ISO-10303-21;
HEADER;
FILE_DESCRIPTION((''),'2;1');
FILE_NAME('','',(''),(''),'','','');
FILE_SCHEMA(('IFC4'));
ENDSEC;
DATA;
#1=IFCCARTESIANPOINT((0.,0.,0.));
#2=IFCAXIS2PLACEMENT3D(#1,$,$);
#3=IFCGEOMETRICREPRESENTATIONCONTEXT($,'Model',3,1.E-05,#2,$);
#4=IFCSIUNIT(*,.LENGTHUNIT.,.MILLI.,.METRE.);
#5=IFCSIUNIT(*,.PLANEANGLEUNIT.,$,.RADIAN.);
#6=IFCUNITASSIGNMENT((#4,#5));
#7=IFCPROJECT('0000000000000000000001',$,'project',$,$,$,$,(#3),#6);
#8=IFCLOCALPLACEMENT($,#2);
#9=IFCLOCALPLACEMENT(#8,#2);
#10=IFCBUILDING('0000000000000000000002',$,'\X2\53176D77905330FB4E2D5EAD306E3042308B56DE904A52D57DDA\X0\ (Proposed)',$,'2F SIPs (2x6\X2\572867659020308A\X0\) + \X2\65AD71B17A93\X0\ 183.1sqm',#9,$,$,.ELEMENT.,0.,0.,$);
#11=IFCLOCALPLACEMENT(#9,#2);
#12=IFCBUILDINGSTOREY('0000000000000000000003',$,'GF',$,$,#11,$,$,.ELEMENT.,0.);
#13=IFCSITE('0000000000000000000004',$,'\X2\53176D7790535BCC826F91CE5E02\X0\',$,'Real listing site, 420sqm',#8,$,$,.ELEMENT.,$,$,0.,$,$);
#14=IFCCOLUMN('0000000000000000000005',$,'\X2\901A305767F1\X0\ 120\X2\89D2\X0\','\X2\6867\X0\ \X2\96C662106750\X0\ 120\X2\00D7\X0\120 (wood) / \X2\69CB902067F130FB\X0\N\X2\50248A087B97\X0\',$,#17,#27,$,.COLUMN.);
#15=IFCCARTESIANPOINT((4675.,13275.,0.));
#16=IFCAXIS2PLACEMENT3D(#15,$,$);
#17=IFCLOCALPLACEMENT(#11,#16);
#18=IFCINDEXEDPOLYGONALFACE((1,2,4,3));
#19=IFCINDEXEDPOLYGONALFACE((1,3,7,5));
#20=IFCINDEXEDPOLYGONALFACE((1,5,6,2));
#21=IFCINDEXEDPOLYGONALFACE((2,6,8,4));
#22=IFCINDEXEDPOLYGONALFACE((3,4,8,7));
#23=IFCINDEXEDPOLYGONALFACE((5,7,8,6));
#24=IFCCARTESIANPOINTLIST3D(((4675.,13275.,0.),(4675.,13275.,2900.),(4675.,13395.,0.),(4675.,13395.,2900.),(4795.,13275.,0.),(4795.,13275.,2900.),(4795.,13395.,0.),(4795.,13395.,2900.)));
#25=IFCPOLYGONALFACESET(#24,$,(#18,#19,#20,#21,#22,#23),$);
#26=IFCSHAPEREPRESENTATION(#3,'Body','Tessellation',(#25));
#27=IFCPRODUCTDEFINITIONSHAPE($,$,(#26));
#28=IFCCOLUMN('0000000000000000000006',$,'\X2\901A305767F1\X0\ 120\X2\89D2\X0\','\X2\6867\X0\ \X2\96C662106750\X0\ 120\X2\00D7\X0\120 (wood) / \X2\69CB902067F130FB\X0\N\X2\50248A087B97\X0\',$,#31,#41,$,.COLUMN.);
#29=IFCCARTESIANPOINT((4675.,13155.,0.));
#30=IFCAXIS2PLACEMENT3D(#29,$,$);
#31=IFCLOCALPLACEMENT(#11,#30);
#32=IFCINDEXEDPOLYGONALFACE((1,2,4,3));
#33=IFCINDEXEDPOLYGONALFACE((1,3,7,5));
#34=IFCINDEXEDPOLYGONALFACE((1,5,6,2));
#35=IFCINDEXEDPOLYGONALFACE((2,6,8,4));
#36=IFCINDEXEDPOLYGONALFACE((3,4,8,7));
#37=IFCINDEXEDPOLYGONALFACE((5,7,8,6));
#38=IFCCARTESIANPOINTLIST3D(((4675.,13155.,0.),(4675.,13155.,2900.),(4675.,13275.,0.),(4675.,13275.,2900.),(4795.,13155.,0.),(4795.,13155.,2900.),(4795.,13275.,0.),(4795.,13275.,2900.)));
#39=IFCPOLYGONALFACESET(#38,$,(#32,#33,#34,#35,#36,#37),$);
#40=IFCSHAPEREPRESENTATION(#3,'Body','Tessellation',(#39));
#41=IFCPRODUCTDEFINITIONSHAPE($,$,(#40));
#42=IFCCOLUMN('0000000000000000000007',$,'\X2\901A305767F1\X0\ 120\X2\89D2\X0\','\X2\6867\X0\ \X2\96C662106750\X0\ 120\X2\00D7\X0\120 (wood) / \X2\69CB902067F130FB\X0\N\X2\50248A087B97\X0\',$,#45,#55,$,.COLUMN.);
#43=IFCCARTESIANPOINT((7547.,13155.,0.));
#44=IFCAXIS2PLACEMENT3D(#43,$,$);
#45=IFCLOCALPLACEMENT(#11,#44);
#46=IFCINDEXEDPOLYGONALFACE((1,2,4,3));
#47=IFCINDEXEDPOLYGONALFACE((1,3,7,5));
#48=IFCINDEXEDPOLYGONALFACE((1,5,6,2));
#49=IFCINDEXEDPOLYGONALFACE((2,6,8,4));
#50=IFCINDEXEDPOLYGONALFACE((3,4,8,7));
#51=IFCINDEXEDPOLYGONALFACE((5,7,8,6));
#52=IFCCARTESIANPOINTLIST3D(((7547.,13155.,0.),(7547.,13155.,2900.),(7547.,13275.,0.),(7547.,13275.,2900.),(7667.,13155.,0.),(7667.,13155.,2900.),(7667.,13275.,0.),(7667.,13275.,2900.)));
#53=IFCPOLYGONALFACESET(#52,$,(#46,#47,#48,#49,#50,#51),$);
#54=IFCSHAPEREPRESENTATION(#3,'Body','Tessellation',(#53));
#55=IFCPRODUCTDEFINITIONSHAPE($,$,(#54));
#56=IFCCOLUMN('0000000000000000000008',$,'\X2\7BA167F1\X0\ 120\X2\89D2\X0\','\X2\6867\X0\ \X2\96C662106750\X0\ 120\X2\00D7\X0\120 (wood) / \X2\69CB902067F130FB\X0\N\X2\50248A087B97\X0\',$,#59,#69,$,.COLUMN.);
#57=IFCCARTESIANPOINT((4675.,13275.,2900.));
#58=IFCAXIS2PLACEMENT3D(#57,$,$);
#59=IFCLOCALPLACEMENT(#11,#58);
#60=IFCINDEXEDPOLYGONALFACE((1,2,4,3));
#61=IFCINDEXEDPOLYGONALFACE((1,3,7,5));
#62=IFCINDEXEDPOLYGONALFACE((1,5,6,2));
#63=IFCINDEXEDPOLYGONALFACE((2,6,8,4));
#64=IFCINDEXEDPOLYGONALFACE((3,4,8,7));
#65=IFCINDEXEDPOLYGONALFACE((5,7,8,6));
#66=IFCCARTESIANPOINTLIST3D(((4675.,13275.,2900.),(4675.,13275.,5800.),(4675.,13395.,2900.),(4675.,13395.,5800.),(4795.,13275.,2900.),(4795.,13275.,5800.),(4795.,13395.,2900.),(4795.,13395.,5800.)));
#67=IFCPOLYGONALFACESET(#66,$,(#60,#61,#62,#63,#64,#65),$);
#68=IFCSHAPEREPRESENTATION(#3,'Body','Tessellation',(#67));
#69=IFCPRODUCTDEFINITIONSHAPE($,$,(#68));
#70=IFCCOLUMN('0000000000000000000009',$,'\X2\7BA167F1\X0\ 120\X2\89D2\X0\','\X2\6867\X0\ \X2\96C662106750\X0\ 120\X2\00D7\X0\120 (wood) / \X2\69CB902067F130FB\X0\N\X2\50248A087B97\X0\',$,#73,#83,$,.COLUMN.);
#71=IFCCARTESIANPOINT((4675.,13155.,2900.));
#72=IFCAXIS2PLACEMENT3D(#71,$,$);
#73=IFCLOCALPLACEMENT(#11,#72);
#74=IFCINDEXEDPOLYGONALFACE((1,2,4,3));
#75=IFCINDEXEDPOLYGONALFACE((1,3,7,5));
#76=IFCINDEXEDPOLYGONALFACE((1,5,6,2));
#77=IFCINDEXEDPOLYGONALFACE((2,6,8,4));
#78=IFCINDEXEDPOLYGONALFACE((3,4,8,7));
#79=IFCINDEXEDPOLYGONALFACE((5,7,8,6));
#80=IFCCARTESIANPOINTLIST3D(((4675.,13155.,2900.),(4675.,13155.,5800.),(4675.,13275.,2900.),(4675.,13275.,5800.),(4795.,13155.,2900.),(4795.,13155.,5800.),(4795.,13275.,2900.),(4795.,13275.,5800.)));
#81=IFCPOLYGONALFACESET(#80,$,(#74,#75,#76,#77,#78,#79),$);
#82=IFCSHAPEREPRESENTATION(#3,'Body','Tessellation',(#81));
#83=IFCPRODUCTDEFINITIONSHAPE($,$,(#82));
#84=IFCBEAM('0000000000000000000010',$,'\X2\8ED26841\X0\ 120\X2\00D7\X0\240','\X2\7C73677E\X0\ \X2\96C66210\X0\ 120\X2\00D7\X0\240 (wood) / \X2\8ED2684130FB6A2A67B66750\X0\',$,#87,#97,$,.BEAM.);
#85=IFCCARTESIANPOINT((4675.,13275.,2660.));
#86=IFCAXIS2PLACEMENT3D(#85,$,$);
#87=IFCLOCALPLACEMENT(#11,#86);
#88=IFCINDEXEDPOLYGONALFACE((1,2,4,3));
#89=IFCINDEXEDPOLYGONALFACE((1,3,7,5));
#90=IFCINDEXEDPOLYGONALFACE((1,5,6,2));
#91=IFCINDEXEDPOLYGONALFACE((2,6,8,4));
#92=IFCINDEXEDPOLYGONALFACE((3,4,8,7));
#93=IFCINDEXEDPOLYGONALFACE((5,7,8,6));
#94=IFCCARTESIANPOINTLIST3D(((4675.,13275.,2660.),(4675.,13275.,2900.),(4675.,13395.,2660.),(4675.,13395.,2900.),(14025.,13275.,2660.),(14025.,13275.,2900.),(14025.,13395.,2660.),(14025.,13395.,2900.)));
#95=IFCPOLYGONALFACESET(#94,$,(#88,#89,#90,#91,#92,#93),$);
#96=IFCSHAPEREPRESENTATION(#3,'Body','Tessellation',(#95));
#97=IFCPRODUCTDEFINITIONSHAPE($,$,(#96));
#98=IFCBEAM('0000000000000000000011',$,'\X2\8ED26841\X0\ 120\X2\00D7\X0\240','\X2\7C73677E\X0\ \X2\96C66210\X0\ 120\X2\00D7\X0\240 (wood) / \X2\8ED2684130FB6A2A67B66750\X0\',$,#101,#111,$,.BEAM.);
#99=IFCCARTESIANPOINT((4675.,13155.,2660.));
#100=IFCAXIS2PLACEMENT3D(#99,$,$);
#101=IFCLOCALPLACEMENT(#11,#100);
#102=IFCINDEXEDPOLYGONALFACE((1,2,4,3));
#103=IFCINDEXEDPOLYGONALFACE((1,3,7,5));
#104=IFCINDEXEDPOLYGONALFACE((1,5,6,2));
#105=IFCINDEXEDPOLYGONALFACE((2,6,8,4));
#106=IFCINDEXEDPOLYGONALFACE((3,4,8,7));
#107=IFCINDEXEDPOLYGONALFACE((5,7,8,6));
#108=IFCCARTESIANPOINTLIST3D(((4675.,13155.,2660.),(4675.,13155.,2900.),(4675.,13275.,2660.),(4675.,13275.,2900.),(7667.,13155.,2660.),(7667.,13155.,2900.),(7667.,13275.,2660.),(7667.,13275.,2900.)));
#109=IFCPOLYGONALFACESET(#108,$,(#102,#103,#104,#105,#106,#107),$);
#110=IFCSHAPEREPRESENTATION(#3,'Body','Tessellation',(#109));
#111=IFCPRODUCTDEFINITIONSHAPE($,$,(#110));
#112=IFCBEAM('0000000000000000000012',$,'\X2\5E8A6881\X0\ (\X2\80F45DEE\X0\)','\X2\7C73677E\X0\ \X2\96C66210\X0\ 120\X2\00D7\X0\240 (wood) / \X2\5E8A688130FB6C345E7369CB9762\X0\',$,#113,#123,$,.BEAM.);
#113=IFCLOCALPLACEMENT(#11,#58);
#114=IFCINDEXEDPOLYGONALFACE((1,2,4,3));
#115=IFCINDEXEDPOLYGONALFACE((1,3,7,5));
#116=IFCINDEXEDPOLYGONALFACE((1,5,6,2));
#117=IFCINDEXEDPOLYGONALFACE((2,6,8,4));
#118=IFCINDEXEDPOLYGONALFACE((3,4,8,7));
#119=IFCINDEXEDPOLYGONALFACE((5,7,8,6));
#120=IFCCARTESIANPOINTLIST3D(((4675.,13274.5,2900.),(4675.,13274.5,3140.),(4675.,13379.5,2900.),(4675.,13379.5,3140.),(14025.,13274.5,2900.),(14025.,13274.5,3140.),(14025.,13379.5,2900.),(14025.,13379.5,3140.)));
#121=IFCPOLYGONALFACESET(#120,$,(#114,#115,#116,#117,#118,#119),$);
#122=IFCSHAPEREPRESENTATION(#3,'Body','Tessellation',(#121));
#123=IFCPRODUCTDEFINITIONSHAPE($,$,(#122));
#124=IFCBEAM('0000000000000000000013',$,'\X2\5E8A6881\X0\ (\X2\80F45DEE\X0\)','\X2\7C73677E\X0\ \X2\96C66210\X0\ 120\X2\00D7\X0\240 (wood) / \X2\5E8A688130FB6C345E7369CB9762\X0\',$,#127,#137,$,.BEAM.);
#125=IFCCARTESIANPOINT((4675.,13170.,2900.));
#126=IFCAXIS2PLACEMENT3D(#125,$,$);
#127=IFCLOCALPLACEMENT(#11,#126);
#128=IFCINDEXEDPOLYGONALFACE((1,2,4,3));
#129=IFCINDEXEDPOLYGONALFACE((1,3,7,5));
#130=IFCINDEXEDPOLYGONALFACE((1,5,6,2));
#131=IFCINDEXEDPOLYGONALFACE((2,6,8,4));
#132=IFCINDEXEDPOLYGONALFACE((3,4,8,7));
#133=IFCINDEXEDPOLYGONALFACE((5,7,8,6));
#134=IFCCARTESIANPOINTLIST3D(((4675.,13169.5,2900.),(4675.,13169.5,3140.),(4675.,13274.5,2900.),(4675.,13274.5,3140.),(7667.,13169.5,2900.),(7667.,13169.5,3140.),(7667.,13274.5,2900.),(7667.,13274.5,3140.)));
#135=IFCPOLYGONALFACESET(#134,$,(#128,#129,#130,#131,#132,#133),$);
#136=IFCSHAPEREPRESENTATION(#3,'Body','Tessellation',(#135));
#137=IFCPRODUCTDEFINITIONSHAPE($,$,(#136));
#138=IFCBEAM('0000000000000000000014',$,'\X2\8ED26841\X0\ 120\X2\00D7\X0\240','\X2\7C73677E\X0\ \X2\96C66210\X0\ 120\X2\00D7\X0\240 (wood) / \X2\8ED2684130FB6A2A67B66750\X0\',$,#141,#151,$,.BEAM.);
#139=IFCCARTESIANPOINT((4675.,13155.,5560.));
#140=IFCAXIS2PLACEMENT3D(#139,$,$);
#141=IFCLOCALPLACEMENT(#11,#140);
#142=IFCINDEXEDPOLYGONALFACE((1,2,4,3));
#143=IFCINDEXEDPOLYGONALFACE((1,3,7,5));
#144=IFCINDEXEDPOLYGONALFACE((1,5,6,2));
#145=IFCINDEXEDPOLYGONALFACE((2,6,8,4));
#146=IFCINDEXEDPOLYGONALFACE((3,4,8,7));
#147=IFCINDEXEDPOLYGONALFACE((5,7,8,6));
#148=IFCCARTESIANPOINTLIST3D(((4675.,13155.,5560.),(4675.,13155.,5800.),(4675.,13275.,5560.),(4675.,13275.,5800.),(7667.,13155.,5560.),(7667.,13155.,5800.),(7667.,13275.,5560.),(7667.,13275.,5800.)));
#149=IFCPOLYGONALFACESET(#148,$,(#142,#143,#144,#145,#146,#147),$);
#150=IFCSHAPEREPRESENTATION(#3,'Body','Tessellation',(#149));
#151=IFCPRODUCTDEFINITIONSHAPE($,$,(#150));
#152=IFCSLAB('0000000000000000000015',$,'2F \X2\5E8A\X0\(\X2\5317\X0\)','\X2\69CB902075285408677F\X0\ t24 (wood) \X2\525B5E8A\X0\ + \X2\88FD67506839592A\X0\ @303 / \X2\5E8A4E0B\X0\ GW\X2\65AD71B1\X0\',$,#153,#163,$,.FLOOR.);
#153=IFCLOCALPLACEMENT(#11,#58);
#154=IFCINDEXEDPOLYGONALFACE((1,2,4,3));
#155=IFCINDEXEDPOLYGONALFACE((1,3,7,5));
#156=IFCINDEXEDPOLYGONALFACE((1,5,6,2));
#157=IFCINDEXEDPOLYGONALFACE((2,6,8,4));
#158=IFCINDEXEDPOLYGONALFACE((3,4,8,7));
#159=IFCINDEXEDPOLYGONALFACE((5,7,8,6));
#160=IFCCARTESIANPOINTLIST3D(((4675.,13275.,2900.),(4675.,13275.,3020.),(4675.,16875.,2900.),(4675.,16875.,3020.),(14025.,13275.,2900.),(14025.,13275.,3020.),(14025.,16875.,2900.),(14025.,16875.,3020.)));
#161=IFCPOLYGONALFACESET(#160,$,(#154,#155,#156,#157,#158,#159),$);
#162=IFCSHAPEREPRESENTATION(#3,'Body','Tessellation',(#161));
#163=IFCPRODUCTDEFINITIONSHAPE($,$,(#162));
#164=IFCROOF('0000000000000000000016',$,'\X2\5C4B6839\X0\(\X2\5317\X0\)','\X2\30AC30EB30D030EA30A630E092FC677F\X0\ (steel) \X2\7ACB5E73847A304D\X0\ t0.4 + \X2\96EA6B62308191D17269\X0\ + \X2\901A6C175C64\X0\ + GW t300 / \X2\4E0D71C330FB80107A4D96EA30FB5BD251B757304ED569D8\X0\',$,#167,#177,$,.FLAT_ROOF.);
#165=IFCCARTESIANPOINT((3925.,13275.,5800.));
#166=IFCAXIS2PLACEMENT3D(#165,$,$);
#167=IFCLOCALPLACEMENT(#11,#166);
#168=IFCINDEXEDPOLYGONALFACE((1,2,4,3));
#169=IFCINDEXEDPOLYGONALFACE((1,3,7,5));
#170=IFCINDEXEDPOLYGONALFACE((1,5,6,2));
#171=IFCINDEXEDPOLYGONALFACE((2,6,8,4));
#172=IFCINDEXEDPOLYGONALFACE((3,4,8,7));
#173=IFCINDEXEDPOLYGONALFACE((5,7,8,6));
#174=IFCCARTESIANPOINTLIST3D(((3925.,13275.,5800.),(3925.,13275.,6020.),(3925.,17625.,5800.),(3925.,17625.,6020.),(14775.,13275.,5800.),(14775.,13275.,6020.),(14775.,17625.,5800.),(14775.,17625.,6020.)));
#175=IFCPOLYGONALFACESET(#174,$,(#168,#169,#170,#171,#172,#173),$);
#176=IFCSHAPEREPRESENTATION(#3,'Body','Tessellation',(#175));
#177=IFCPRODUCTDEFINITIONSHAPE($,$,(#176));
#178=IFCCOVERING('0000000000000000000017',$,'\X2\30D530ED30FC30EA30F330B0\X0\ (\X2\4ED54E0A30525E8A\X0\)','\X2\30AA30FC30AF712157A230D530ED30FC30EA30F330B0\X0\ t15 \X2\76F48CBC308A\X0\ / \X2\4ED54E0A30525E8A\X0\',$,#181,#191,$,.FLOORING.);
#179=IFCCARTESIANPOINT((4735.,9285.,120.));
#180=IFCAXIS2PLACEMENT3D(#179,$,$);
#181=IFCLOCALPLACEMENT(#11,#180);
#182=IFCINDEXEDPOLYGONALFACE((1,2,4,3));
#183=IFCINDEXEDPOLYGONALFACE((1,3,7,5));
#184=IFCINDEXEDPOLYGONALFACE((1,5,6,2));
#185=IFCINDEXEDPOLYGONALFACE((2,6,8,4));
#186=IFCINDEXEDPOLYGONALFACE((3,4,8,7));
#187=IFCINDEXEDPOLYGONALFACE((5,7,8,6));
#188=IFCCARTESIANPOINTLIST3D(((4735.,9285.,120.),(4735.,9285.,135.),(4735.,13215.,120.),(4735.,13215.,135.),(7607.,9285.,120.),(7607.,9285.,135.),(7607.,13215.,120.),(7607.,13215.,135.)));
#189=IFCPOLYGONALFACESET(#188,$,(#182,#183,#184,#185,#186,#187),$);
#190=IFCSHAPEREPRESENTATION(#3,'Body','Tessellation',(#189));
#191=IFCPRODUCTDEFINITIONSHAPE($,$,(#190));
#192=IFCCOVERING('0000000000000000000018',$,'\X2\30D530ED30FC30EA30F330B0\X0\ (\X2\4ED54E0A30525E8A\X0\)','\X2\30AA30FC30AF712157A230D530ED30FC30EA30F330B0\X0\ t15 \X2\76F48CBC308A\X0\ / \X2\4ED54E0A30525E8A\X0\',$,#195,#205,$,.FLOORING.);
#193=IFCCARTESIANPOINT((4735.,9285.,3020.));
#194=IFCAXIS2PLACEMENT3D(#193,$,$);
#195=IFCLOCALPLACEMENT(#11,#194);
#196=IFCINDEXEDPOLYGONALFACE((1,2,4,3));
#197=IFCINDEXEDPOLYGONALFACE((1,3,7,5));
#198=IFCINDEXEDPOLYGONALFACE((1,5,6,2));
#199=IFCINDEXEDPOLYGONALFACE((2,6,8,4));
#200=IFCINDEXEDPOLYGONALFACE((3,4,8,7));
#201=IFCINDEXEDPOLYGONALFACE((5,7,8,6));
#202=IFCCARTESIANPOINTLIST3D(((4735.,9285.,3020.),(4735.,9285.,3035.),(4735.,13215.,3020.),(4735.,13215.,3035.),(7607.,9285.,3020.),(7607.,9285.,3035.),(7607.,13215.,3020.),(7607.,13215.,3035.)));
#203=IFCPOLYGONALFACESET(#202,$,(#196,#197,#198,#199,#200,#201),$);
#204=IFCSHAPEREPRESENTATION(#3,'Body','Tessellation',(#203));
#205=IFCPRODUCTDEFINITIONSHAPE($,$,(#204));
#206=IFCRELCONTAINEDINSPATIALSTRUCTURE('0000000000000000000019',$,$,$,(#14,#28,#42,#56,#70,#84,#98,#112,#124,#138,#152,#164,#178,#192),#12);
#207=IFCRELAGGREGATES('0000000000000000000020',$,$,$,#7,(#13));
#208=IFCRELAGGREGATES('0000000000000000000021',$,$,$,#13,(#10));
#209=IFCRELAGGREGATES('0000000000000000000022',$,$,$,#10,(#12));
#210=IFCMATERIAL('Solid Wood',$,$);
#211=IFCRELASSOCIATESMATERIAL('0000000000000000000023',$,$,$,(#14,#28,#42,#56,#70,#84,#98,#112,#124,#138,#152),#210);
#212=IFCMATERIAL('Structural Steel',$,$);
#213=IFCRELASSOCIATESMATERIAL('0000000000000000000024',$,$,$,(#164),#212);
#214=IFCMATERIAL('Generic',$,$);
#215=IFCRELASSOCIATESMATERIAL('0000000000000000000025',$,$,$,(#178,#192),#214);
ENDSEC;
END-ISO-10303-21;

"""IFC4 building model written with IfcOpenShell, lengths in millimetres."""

from ifc_helpers import new_model, si_unit, frame, frame_2d, origin, place, context, project, spatial, rectangle, extrude, material, element, save


model = new_model("IFC4")

# Units and contexts
model_context = context("Model", 3, precision=1e-05, world=origin())
ifc_project = project(units=[si_unit("LENGTHUNIT", "METRE", prefix="MILLI"), si_unit("PLANEANGLEUNIT", "RADIAN")], contexts=[model_context])

# Site, building, storey
site_placement = place(None, origin())
site = spatial("IfcSite", under=ifc_project, at=site_placement, Name="北海道富良野市", ObjectType="Real listing site, 420sqm", CompositionType="ELEMENT", RefElevation=0.0)
building_placement = place(site_placement, origin())
building = spatial("IfcBuilding", under=site, at=building_placement, Name="北海道・中庭のある回遊動線 (Proposed)", ObjectType="2F SIPs (2x6在来造り) + 断熱窓 183.1sqm", CompositionType="ELEMENT", ElevationOfRefHeight=0.0, ElevationOfTerrain=0.0)
storey_placement = place(building_placement, origin())
storey = spatial("IfcBuildingStorey", under=building, at=storey_placement, Name="GF", CompositionType="ELEMENT", Elevation=0.0)

# Columns
ifc_material_1 = material(Name="Solid Wood")
column_1_placement = place(storey_placement, frame((4675.0, 13275.0, 0.0)))
element("IfcColumn", 1, at=column_1_placement, inside=storey, material=ifc_material_1, Name="通し柱 120角", Description="桧 集成材 120×120 (wood) / 構造柱・N値計算", PredefinedType="COLUMN", context=model_context, shape_type="SweptSolid", body=[
    extrude(rectangle(XDim=120.0, YDim=120.0, at=frame_2d((60.0, 60.0))), frame((4675.0, 13275.0, 0.0)), (0.0, 0.0, 1.0), 2900.0),
])
column_2_placement = place(storey_placement, frame((4675.0, 13155.0, 0.0)))
element("IfcColumn", 2, at=column_2_placement, inside=storey, material=ifc_material_1, Name="通し柱 120角", Description="桧 集成材 120×120 (wood) / 構造柱・N値計算", PredefinedType="COLUMN", context=model_context, shape_type="SweptSolid", body=[
    extrude(rectangle(XDim=120.0, YDim=120.0, at=frame_2d((60.0, 60.0))), frame((4675.0, 13155.0, 0.0)), (0.0, 0.0, 1.0), 2900.0),
])
column_3_placement = place(storey_placement, frame((7547.0, 13155.0, 0.0)))
element("IfcColumn", 3, at=column_3_placement, inside=storey, material=ifc_material_1, Name="通し柱 120角", Description="桧 集成材 120×120 (wood) / 構造柱・N値計算", PredefinedType="COLUMN", context=model_context, shape_type="SweptSolid", body=[
    extrude(rectangle(XDim=120.0, YDim=120.0, at=frame_2d((60.0, 60.0))), frame((7547.0, 13155.0, 0.0)), (0.0, 0.0, 1.0), 2900.0),
])
column_4_placement = place(storey_placement, frame((4675.0, 13275.0, 2900.0)))
element("IfcColumn", 4, at=column_4_placement, inside=storey, material=ifc_material_1, Name="管柱 120角", Description="桧 集成材 120×120 (wood) / 構造柱・N値計算", PredefinedType="COLUMN", context=model_context, shape_type="SweptSolid", body=[
    extrude(rectangle(XDim=120.0, YDim=120.0, at=frame_2d((60.0, 60.0))), frame((4675.0, 13275.0, 2900.0)), (0.0, 0.0, 1.0), 2900.0),
])
column_5_placement = place(storey_placement, frame((4675.0, 13155.0, 2900.0)))
element("IfcColumn", 5, at=column_5_placement, inside=storey, material=ifc_material_1, Name="管柱 120角", Description="桧 集成材 120×120 (wood) / 構造柱・N値計算", PredefinedType="COLUMN", context=model_context, shape_type="SweptSolid", body=[
    extrude(rectangle(XDim=120.0, YDim=120.0, at=frame_2d((60.0, 60.0))), frame((4675.0, 13155.0, 2900.0)), (0.0, 0.0, 1.0), 2900.0),
])

# Beams
beam_1_placement = place(storey_placement, frame((4675.0, 13275.0, 2660.0)))
element("IfcBeam", 6, at=beam_1_placement, inside=storey, material=ifc_material_1, Name="軒桁 120×240", Description="米松 集成 120×240 (wood) / 軒桁・横架材", PredefinedType="BEAM", context=model_context, shape_type="SweptSolid", body=[
    extrude(rectangle(XDim=9350.0, YDim=120.0, at=frame_2d((4675.0, 60.0))), frame((4675.0, 13275.0, 2660.0)), (0.0, 0.0, 1.0), 240.0),
])
beam_2_placement = place(storey_placement, frame((4675.0, 13155.0, 2660.0)))
element("IfcBeam", 7, at=beam_2_placement, inside=storey, material=ifc_material_1, Name="軒桁 120×240", Description="米松 集成 120×240 (wood) / 軒桁・横架材", PredefinedType="BEAM", context=model_context, shape_type="SweptSolid", body=[
    extrude(rectangle(XDim=2992.0, YDim=120.0, at=frame_2d((1496.0, 60.0))), frame((4675.0, 13155.0, 2660.0)), (0.0, 0.0, 1.0), 240.0),
])
beam_3_placement = place(storey_placement, frame((4675.0, 13275.0, 2900.0)))
element("IfcBeam", 8, at=beam_3_placement, inside=storey, material=ifc_material_1, Name="床梁 (胴差)", Description="米松 集成 120×240 (wood) / 床梁・水平構面", PredefinedType="BEAM", context=model_context, shape_type="SweptSolid", body=[
    extrude(rectangle(XDim=9350.0, YDim=105.0, at=frame_2d((4675.0, 52.0))), frame((4675.0, 13275.0, 2900.0)), (0.0, 0.0, 1.0), 240.0),
])
beam_4_placement = place(storey_placement, frame((4675.0, 13170.0, 2900.0)))
element("IfcBeam", 9, at=beam_4_placement, inside=storey, material=ifc_material_1, Name="床梁 (胴差)", Description="米松 集成 120×240 (wood) / 床梁・水平構面", PredefinedType="BEAM", context=model_context, shape_type="SweptSolid", body=[
    extrude(rectangle(XDim=2992.0, YDim=105.0, at=frame_2d((1496.0, 52.0))), frame((4675.0, 13170.0, 2900.0)), (0.0, 0.0, 1.0), 240.0),
])
beam_5_placement = place(storey_placement, frame((4675.0, 13155.0, 5560.0)))
element("IfcBeam", 10, at=beam_5_placement, inside=storey, material=ifc_material_1, Name="軒桁 120×240", Description="米松 集成 120×240 (wood) / 軒桁・横架材", PredefinedType="BEAM", context=model_context, shape_type="SweptSolid", body=[
    extrude(rectangle(XDim=2992.0, YDim=120.0, at=frame_2d((1496.0, 60.0))), frame((4675.0, 13155.0, 5560.0)), (0.0, 0.0, 1.0), 240.0),
])

# Slab
slab_1_placement = place(storey_placement, frame((4675.0, 13275.0, 2900.0)))
element("IfcSlab", 11, at=slab_1_placement, inside=storey, material=ifc_material_1, Name="2F 床(北)", Description="構造用合板 t24 (wood) 剛床 + 製材根太 @303 / 床下 GW断熱", PredefinedType="FLOOR", context=model_context, shape_type="SweptSolid", body=[
    extrude(rectangle(XDim=9350.0, YDim=3600.0, at=frame_2d((4675.0, 1800.0))), frame((4675.0, 13275.0, 2900.0)), (0.0, 0.0, 1.0), 120.0),
])

# Roof
ifc_material_2 = material(Name="Structural Steel")
for number, where, name in (
    (12, (3925.0, 13275.0, 5800.0), "屋根(北)"),
):
    element("IfcRoof", number, at=place(storey_placement, frame(where)), inside=storey, material=ifc_material_2, Name=name, Description="ガルバリウム鋼板 (steel) 立平葺き t0.4 + 雪止め金物 + 通気層 + GW t300 / 不燃・耐積雪・寒冷地仕様", PredefinedType="FLAT_ROOF", context=model_context, shape_type="SweptSolid", body=[
        extrude(rectangle(XDim=10850.0, YDim=4350.0, at=frame_2d((5425.0, 2175.0))), frame((3925.0, 13275.0, 5800.0)), (0.0, 0.0, 1.0), 220.0),
    ])

# Coverings
ifc_material_3 = material(Name="Generic")
covering_1_placement = place(storey_placement, frame((4735.0, 9285.0, 120.0)))
element("IfcCovering", 13, at=covering_1_placement, inside=storey, material=ifc_material_3, Name="フローリング (仕上げ床)", Description="オーク無垢フローリング t15 直貼り / 仕上げ床", PredefinedType="FLOORING", context=model_context, shape_type="SweptSolid", body=[
    extrude(rectangle(XDim=2872.0, YDim=3930.0, at=frame_2d((1436.0, 1965.0))), frame((4735.0, 9285.0, 120.0)), (0.0, 0.0, 1.0), 15.0),
])
covering_2_placement = place(storey_placement, frame((4735.0, 9285.0, 3020.0)))
element("IfcCovering", 14, at=covering_2_placement, inside=storey, material=ifc_material_3, Name="フローリング (仕上げ床)", Description="オーク無垢フローリング t15 直貼り / 仕上げ床", PredefinedType="FLOORING", context=model_context, shape_type="SweptSolid", body=[
    extrude(rectangle(XDim=2872.0, YDim=3930.0, at=frame_2d((1436.0, 1965.0))), frame((4735.0, 9285.0, 3020.0)), (0.0, 0.0, 1.0), 15.0),
])

save(model, "model.ifc")
